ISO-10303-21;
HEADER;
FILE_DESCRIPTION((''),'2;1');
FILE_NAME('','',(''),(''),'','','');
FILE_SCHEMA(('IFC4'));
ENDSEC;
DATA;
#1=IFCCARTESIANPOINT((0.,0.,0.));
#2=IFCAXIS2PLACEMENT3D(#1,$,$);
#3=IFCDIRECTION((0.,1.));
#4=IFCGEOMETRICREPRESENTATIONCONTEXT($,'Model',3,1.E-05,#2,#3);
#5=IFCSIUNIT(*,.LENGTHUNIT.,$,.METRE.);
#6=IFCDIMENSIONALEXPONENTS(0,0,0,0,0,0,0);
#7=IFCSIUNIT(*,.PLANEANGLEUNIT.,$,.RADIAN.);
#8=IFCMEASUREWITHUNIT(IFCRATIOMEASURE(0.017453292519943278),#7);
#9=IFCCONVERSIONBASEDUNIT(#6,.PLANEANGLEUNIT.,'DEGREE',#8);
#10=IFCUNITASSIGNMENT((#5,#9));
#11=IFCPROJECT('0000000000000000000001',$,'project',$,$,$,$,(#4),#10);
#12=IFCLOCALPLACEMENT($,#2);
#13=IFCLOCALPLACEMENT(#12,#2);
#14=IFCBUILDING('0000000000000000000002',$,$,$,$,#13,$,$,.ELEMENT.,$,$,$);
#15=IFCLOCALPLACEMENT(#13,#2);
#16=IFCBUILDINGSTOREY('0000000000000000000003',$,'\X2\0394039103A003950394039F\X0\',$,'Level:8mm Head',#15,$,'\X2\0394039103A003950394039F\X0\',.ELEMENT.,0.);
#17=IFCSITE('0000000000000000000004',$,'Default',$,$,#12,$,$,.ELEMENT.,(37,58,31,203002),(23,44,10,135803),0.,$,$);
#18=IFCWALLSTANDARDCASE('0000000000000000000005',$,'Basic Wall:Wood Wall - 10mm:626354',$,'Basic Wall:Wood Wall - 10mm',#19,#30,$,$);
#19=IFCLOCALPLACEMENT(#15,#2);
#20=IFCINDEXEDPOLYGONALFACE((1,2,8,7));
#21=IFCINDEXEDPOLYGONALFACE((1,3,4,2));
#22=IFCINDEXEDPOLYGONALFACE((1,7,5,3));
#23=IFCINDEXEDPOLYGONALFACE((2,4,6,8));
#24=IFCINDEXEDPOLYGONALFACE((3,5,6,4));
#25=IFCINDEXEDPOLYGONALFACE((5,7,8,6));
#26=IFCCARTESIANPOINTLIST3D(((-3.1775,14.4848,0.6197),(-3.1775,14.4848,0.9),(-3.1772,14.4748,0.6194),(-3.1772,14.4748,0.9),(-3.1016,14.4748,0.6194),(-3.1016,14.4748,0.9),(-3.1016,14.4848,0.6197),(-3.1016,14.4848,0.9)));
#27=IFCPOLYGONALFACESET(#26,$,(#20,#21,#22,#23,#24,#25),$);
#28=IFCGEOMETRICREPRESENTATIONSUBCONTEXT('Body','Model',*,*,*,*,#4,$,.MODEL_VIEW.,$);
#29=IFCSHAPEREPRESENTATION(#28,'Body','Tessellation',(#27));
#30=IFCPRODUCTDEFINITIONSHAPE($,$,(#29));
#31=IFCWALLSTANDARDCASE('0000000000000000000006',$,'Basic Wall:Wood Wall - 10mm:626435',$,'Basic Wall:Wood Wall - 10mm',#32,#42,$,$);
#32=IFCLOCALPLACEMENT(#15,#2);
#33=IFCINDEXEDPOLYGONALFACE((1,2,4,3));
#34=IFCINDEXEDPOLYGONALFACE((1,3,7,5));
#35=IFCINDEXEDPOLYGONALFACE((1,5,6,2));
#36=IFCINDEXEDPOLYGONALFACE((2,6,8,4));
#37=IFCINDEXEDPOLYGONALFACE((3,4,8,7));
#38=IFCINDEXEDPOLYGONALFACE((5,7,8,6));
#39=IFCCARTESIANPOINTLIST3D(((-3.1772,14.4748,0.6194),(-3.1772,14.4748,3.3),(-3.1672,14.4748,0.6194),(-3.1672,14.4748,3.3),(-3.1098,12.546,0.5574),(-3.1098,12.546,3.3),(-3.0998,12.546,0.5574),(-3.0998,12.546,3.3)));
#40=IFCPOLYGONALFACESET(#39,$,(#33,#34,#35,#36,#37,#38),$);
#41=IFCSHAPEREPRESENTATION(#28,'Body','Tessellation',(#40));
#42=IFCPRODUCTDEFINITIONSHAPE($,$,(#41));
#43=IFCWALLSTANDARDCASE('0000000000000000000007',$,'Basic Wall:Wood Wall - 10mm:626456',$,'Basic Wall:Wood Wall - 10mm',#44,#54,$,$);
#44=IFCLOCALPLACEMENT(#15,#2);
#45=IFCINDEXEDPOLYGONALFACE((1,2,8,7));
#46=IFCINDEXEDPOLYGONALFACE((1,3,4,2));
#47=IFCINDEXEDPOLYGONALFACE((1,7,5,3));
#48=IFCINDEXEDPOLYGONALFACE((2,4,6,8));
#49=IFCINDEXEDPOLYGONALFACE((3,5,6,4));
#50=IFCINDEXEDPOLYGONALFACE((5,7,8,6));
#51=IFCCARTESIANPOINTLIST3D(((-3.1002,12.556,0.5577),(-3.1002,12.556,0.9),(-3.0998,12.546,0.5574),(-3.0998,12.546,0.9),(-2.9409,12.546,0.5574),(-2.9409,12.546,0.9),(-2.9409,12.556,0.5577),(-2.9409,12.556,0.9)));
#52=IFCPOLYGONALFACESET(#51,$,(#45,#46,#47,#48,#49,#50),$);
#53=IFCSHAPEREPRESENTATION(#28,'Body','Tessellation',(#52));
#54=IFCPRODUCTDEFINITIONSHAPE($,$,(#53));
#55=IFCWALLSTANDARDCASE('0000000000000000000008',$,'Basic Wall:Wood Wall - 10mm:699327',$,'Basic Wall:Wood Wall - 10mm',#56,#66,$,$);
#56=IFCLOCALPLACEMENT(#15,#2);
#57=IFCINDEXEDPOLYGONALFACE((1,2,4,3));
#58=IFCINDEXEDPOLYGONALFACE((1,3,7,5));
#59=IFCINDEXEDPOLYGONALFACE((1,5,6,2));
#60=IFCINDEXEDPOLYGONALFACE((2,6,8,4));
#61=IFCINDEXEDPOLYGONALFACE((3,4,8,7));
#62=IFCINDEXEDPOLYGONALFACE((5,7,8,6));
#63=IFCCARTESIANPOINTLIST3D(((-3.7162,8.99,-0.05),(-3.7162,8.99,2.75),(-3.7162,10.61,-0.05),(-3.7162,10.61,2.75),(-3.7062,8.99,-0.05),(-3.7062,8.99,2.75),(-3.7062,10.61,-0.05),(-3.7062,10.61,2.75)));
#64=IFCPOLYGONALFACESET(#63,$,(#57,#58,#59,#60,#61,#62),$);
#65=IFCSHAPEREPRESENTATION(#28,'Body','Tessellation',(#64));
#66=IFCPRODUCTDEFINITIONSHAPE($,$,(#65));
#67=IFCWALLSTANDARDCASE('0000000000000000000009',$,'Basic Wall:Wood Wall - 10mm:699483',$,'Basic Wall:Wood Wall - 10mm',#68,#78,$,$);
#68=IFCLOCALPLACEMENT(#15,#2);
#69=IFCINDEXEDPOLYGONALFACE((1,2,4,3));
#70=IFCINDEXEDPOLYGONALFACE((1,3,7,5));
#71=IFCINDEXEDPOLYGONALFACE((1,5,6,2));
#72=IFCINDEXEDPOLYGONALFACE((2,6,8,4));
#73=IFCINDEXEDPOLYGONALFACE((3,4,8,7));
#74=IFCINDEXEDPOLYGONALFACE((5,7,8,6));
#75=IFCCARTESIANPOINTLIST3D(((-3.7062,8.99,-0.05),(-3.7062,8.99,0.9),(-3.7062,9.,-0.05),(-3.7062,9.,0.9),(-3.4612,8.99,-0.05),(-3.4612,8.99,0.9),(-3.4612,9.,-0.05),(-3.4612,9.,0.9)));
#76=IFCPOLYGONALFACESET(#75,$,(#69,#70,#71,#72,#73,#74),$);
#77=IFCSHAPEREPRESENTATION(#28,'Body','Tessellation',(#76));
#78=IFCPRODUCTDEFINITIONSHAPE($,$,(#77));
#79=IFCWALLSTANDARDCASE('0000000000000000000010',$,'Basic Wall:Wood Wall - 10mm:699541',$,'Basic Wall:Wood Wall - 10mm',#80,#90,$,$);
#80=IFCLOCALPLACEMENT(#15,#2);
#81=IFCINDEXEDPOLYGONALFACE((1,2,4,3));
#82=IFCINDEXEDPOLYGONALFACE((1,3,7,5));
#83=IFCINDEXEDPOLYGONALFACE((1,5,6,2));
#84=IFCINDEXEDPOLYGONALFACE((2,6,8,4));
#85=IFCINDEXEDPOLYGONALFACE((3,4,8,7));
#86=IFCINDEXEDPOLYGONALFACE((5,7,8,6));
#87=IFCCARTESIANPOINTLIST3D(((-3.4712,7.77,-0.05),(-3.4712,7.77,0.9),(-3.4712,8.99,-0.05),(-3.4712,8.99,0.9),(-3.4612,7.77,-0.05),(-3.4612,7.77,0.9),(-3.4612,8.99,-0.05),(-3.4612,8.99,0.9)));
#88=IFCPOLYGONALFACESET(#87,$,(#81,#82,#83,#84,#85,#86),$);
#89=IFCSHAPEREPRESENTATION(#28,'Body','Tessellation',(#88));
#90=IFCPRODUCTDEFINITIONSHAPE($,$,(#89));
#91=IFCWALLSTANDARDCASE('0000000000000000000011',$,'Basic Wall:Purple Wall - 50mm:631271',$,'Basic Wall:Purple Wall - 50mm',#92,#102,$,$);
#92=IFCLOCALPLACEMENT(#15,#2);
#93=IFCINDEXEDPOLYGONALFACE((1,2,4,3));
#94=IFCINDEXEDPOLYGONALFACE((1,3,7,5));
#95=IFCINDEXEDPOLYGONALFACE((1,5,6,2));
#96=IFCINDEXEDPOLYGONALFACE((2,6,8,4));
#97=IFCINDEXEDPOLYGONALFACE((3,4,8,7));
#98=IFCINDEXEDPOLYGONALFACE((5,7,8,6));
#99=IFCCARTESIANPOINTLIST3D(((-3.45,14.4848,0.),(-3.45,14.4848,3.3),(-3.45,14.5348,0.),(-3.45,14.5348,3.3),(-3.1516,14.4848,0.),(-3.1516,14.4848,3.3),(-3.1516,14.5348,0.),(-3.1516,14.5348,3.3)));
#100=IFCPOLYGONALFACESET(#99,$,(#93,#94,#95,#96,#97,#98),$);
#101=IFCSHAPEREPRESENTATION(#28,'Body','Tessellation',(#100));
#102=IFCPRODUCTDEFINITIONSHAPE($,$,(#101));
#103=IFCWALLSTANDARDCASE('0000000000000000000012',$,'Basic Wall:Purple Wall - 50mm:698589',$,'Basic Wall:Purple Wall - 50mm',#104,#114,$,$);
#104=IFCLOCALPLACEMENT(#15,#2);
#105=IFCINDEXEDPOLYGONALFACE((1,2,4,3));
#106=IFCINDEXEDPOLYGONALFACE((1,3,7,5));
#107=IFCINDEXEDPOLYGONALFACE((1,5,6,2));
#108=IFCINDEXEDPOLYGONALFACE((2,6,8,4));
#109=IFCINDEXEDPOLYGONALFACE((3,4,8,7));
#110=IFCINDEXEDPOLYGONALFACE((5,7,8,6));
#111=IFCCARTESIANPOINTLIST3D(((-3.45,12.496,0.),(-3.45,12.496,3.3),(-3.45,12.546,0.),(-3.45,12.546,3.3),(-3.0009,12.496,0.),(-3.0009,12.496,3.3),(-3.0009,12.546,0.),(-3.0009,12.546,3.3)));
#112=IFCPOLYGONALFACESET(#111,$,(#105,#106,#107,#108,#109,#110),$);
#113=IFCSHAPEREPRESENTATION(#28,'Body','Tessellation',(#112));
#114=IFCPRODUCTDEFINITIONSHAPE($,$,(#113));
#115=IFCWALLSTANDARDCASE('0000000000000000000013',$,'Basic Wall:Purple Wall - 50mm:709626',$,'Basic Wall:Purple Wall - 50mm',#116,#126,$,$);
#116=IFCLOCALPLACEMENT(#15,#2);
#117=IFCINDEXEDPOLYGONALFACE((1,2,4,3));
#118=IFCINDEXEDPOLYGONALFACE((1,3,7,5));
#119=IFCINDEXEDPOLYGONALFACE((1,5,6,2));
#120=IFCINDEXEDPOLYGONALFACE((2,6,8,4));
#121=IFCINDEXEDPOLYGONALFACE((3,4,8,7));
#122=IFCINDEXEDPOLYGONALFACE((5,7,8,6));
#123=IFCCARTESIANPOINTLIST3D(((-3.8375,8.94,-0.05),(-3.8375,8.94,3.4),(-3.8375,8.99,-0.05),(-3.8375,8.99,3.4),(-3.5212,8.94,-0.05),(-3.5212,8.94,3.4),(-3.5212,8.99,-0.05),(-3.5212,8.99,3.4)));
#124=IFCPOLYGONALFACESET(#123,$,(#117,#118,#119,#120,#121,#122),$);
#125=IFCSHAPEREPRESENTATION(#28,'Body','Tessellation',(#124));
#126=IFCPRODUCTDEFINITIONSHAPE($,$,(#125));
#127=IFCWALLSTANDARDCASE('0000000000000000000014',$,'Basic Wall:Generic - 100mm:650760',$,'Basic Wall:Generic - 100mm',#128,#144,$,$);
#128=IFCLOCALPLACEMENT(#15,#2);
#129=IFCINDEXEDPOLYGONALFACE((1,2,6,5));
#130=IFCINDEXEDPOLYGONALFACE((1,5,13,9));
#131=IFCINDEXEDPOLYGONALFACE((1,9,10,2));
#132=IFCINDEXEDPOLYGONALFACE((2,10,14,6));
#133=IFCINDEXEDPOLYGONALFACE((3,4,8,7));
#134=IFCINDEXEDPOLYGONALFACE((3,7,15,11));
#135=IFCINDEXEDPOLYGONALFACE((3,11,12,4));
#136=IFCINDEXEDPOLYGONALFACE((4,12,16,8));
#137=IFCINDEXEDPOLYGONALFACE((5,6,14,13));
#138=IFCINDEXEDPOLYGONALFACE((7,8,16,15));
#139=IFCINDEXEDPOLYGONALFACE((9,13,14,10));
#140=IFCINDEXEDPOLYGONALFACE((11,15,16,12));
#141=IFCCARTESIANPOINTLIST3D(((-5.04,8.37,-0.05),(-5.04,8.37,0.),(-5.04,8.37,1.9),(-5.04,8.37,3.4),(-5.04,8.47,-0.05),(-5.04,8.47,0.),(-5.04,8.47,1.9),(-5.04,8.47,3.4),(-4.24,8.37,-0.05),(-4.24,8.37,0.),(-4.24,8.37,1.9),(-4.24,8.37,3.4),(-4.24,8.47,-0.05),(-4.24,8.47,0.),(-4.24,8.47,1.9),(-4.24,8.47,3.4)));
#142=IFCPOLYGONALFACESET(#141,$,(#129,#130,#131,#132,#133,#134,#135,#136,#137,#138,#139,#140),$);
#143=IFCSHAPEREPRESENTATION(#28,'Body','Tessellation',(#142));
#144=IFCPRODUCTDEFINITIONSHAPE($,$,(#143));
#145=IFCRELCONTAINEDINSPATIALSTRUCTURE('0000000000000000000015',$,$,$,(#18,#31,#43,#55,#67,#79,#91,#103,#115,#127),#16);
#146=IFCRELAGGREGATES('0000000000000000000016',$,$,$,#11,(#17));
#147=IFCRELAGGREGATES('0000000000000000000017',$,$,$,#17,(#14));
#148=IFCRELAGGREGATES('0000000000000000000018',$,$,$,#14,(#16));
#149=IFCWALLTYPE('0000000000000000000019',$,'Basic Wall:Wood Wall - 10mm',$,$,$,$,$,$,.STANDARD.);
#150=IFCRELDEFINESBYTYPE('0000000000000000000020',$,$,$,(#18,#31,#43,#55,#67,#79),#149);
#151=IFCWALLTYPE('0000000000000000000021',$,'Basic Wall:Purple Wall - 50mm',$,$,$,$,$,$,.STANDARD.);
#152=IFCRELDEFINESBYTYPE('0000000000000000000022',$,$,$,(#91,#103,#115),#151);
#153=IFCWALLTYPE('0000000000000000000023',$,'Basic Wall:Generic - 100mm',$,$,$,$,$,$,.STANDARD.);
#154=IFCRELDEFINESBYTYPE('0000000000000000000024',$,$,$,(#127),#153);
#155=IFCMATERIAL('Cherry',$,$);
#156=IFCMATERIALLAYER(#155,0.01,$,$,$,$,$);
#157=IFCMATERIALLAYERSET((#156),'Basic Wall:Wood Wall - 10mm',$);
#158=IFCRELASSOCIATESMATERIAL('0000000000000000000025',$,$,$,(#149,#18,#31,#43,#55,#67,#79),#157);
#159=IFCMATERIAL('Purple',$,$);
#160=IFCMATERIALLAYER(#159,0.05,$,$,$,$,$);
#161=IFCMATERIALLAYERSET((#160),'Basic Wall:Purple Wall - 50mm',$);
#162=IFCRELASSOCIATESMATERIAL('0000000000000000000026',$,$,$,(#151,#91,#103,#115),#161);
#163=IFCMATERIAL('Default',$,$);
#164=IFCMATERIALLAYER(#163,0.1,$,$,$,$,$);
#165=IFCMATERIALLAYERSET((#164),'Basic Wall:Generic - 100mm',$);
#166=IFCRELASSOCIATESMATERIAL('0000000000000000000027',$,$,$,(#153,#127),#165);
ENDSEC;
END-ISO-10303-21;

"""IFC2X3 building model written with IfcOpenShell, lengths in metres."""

from ifc_helpers import new_model, entity, si_unit, converted_unit, direction, frame, frame_2d, origin, place, context, subcontext, project, spatial, polyline, rectangle, outline, extrude, clip, bounded_halfspace, material, layer, layer_set, layer_usage, type_object, element, save


model = new_model("IFC2X3")

# Units and contexts
model_context = context("Model", 3, precision=1e-05, world=origin(), true_north=direction((0.0, 1.0)))
body_context = subcontext(model_context, "Body", "Model", "MODEL_VIEW")
ifc_project = project(units=[si_unit("LENGTHUNIT", "METRE"), converted_unit("PLANEANGLEUNIT", "DEGREE", entity("IfcRatioMeasure", 0.017453292519943278), si_unit("PLANEANGLEUNIT", "RADIAN"), dimensions=[0, 0, 0, 0, 0, 0, 0])], contexts=[model_context])

# Site, building, storey
site_placement = place(None, origin())
site = spatial("IfcSite", under=ifc_project, at=site_placement, Name="Default", CompositionType="ELEMENT", RefLatitude=(37, 58, 31, 203002), RefLongitude=(23, 44, 10, 135803), RefElevation=0.0)
building_placement = place(site_placement, origin())
building = spatial("IfcBuilding", under=site, at=building_placement, CompositionType="ELEMENT")
storey_placement = place(building_placement, origin())
storey = spatial("IfcBuildingStorey", under=building, at=storey_placement, Name="ΔΑΠΕΔΟ", ObjectType="Level:8mm Head", LongName="ΔΑΠΕΔΟ", CompositionType="ELEMENT", Elevation=0.0)

# Walls
ifc_material_1 = material(Name="Cherry")
ifc_layer_1 = layer(ifc_material_1, 0.01)
ifc_layer_set_1 = layer_set([ifc_layer_1], Name="Basic Wall:Wood Wall - 10mm")
ifc_layer_usage_1 = layer_usage(ifc_layer_set_1, "AXIS2", "POSITIVE", -0.005)
wall_type_1 = type_object("IfcWallType", Name="Basic Wall:Wood Wall - 10mm", PredefinedType="STANDARD", material=ifc_layer_set_1)
wall_1_placement = place(storey_placement, frame((-3.1016, 14.4798, 0.6194), z_axis=(0.0, 0.0, 1.0), x_axis=(-1.0, 0.0, 0.0)))
element("IfcWallStandardCase", 1, at=wall_1_placement, inside=storey, type_object=wall_type_1, material=ifc_layer_usage_1, Name="Basic Wall:Wood Wall - 10mm:626354", ObjectType="Basic Wall:Wood Wall - 10mm", context=body_context, shape_type="Clipping", body=[
    clip(extrude(outline(polyline([(0.0, -0.005), (0.076, -0.005), (0.0756, 0.005), (0.0, 0.005), (0.0, -0.005)])), origin(), (0.0, 0.0, 1.0), 0.2806), bounded_halfspace(frame((0.076, -0.005, 0.0003), z_axis=(0.0, 0.032108, 0.999484), x_axis=(-1.0, 0.0, 0.0)), True, frame((0.076, -0.005, 0.0003)), polyline([(0.0, 0.0), (-0.0003, 0.01), (-0.0104, 0.01), (-0.076, 0.01), (-0.076, 0.0), (0.0, 0.0)]))),
])
wall_2_placement = place(storey_placement, frame((-3.1722, 14.475, 0.5574), z_axis=(0.0, 0.0, 1.0), x_axis=(0.034899, -0.999391, 0.0)))
element("IfcWallStandardCase", 2, at=wall_2_placement, inside=storey, type_object=wall_type_1, material=ifc_layer_usage_1, Name="Basic Wall:Wood Wall - 10mm:626435", ObjectType="Basic Wall:Wood Wall - 10mm", context=body_context, shape_type="Clipping", body=[
    clip(extrude(outline(polyline([(0.0, -0.005), (1.93, -0.005), (1.9303, 0.005), (0.0003, 0.005), (0.0, -0.005)])), origin(), (0.0, 0.0, 1.0), 2.7426), bounded_halfspace(frame((1.93, -0.005, 0.0), z_axis=(0.032088, -0.001121, 0.999484), x_axis=(0.034899, 0.999391, 0.0)), True, frame((1.93, -0.005, 0.0)), polyline([(0.0, 0.0), (0.0003, 0.01), (-0.0097, 0.01), (-1.9296, 0.01), (-1.93, 0.0), (0.0, 0.0)]))),
])
wall_3_placement = place(storey_placement, frame((-3.1002, 12.551, 0.5574)))
element("IfcWallStandardCase", 3, at=wall_3_placement, inside=storey, type_object=wall_type_1, material=ifc_layer_usage_1, Name="Basic Wall:Wood Wall - 10mm:626456", ObjectType="Basic Wall:Wood Wall - 10mm", context=body_context, shape_type="Clipping", body=[
    clip(extrude(outline(polyline([(0.0003, -0.005), (0.1492, -0.005), (0.1592, -0.005), (0.1592, 0.005), (0.0, 0.005), (0.0003, -0.005)])), origin(), (0.0, 0.0, 1.0), 0.3426), bounded_halfspace(frame((0.1592, -0.005, 0.0), z_axis=(0.0, -0.032108, 0.999484), x_axis=(1.0, 0.0, 0.0)), True, frame((0.1592, -0.005, 0.0)), polyline([(0.0, 0.0), (0.0, 0.01), (-0.1592, 0.01), (-0.1589, 0.0), (-0.01, 0.0), (0.0, 0.0)]))),
])
ifc_layer_usage_2 = layer_usage(ifc_layer_set_1, "AXIS2", "NEGATIVE", 0.005)
wall_4_placement = place(storey_placement, frame((-3.7112, 10.61, -0.05), z_axis=(0.0, 0.0, 1.0), x_axis=(0.0, -1.0, 0.0)))
element("IfcWallStandardCase", 4, at=wall_4_placement, inside=storey, type_object=wall_type_1, material=ifc_layer_usage_2, Name="Basic Wall:Wood Wall - 10mm:699327", ObjectType="Basic Wall:Wood Wall - 10mm", context=body_context, shape_type="Clipping", body=[
    clip(clip(extrude(rectangle(XDim=1.62, YDim=0.01, at=frame_2d((0.81, 0.0), x_axis=(-1.0, 0.0))), origin(), (0.0, 0.0, 1.0), 2.8), bounded_halfspace(frame((0.0, -0.005, 2.8), z_axis=(0.0, 0.0, -1.0), x_axis=(0.0, 1.0, 0.0)), True, frame((0.0, -0.005, 2.8)), polyline([(0.0, 0.0), (1.62, 0.0), (1.62, 0.01), (0.0, 0.01), (0.0, 0.0)]))), bounded_halfspace(frame((1.62, -0.005, 0.0), z_axis=(0.0, 0.0, 1.0), x_axis=(-1.0, 0.0, 0.0)), True, frame((1.62, -0.005, 0.0), z_axis=(0.0, 0.0, 1.0), x_axis=(-1.0, 0.0, 0.0)), polyline([(0.0, 0.0), (0.0, -0.01), (0.01, -0.01), (1.62, -0.01), (1.62, 0.0), (0.0, 0.0)]))),
])
wall_5_placement = place(storey_placement, frame((-3.7062, 8.995, -0.05)))
element("IfcWallStandardCase", 5, at=wall_5_placement, inside=storey, type_object=wall_type_1, material=ifc_layer_usage_2, Name="Basic Wall:Wood Wall - 10mm:699483", ObjectType="Basic Wall:Wood Wall - 10mm", context=body_context, shape_type="Clipping", body=[
    clip(extrude(rectangle(XDim=0.245, YDim=0.01, at=frame_2d((0.1225, 0.0), x_axis=(-1.0, 0.0))), origin(), (0.0, 0.0, 1.0), 0.95), bounded_halfspace(frame((0.245, -0.005, 0.0), z_axis=(0.0, 0.0, 1.0), x_axis=(0.0, 1.0, 0.0)), True, frame((0.245, -0.005, 0.0), z_axis=(0.0, 0.0, 1.0), x_axis=(0.0, 1.0, 0.0)), polyline([(0.0, 0.0), (0.01, 0.0), (0.01, 0.245), (0.0, 0.245), (0.0, 0.06), (0.0, 0.01), (0.0, 0.0)]))),
])
wall_6_placement = place(storey_placement, frame((-3.4662, 8.99, -0.05), z_axis=(0.0, 0.0, 1.0), x_axis=(0.0, -1.0, 0.0)))
element("IfcWallStandardCase", 6, at=wall_6_placement, inside=storey, type_object=wall_type_1, material=ifc_layer_usage_2, Name="Basic Wall:Wood Wall - 10mm:699541", ObjectType="Basic Wall:Wood Wall - 10mm", context=body_context, shape_type="Clipping", body=[
    clip(extrude(rectangle(XDim=1.22, YDim=0.01, at=frame_2d((0.61, 0.0), x_axis=(-1.0, 0.0))), origin(), (0.0, 0.0, 1.0), 0.95), bounded_halfspace(frame((1.22, -0.005, 0.0), z_axis=(0.0, 0.0, 1.0), x_axis=(-1.0, 0.0, 0.0)), True, frame((1.22, -0.005, 0.0), z_axis=(0.0, 0.0, 1.0), x_axis=(-1.0, 0.0, 0.0)), polyline([(0.0, 0.0), (0.0, -0.01), (0.01, -0.01), (1.22, -0.01), (1.22, 0.0), (0.06, 0.0), (0.01, 0.0), (0.0, 0.0)]))),
])
ifc_material_2 = material(Name="Purple")
ifc_layer_2 = layer(ifc_material_2, 0.05)
ifc_layer_set_2 = layer_set([ifc_layer_2], Name="Basic Wall:Purple Wall - 50mm")
ifc_layer_usage_3 = layer_usage(ifc_layer_set_2, "AXIS2", "NEGATIVE", 0.025)
wall_type_2 = type_object("IfcWallType", Name="Basic Wall:Purple Wall - 50mm", PredefinedType="STANDARD", material=ifc_layer_set_2)
wall_7_placement = place(storey_placement, frame((-3.1516, 14.5098, 0.0), z_axis=(0.0, 0.0, 1.0), x_axis=(-1.0, 0.0, 0.0)))
element("IfcWallStandardCase", 7, at=wall_7_placement, inside=storey, type_object=wall_type_2, material=ifc_layer_usage_3, Name="Basic Wall:Purple Wall - 50mm:631271", ObjectType="Basic Wall:Purple Wall - 50mm", context=body_context, shape_type="Clipping", body=[
    clip(extrude(rectangle(XDim=0.2984, YDim=0.05, at=frame_2d((0.1492, 0.0), x_axis=(-1.0, 0.0))), origin(), (0.0, 0.0, 1.0), 3.3), bounded_halfspace(frame((0.0, -0.025, 0.0), z_axis=(1.0, 0.0, 0.0), x_axis=(0.0, 1.0, 0.0)), True, frame((0.0, -0.025, 0.0), z_axis=(1.0, 0.0, 0.0), x_axis=(0.0, 1.0, 0.0)), polyline([(0.0, 0.0), (0.05, 0.0), (0.05, 3.3), (0.0, 3.3), (0.0, 0.6213), (0.0, 0.5713), (0.0, 0.0)]))),
])
wall_8_placement = place(storey_placement, frame((-3.45, 12.521, 0.0)))
element("IfcWallStandardCase", 8, at=wall_8_placement, inside=storey, type_object=wall_type_2, material=ifc_layer_usage_3, Name="Basic Wall:Purple Wall - 50mm:698589", ObjectType="Basic Wall:Purple Wall - 50mm", context=body_context, shape_type="SweptSolid", body=[
    extrude(rectangle(XDim=0.4491, YDim=0.05, at=frame_2d((0.2245, 0.0), x_axis=(-1.0, 0.0))), origin(), (0.0, 0.0, 1.0), 3.3),
])
ifc_layer_usage_4 = layer_usage(ifc_layer_set_2, "AXIS2", "POSITIVE", -0.025)
wall_9_placement = place(storey_placement, frame((-3.5212, 8.965, -0.05), z_axis=(0.0, 0.0, 1.0), x_axis=(-1.0, 0.0, 0.0)))
element("IfcWallStandardCase", 9, at=wall_9_placement, inside=storey, type_object=wall_type_2, material=ifc_layer_usage_4, Name="Basic Wall:Purple Wall - 50mm:709626", ObjectType="Basic Wall:Purple Wall - 50mm", context=body_context, shape_type="Clipping", body=[
    clip(clip(extrude(rectangle(XDim=0.3162, YDim=0.05, at=frame_2d((0.1581, 0.0), x_axis=(-1.0, 0.0))), origin(), (0.0, 0.0, 1.0), 3.45), bounded_halfspace(frame((0.0, -0.025, 3.45), z_axis=(0.0, 0.0, -1.0), x_axis=(0.0, 1.0, 0.0)), True, frame((0.0, -0.025, 3.45), z_axis=(0.0, 0.0, -1.0), x_axis=(0.0, 1.0, 0.0)), polyline([(0.0, 0.0), (0.05, 0.0), (0.05, 0.3162), (0.0, 0.3162), (0.0, 0.0)]))), bounded_halfspace(frame((0.3162, -0.025, 0.0), z_axis=(0.0, 0.0, 1.0), x_axis=(0.0, -1.0, 0.0)), True, frame((0.3162, -0.025, 0.0), z_axis=(0.0, 0.0, 1.0), x_axis=(0.0, -1.0, 0.0)), polyline([(0.0, 0.0), (-0.05, 0.0), (-0.05, -0.3162), (0.0, -0.3162), (0.0, -0.1312), (0.0, -0.1212), (0.0, 0.0)]))),
])

# Wall, opening
ifc_material_3 = material(Name="Default")
ifc_layer_3 = layer(ifc_material_3, 0.1)
ifc_layer_set_3 = layer_set([ifc_layer_3], Name="Basic Wall:Generic - 100mm")
ifc_layer_usage_5 = layer_usage(ifc_layer_set_3, "AXIS2", "NEGATIVE", 0.05)
wall_type_3 = type_object("IfcWallType", Name="Basic Wall:Generic - 100mm", PredefinedType="STANDARD", material=ifc_layer_set_3)
wall_10_placement = place(storey_placement, frame((-4.24, 8.42, -0.05), z_axis=(0.0, 0.0, 1.0), x_axis=(-1.0, 0.0, 0.0)))
wall_10 = element("IfcWallStandardCase", 10, at=wall_10_placement, inside=storey, type_object=wall_type_3, material=ifc_layer_usage_5, Name="Basic Wall:Generic - 100mm:650760", ObjectType="Basic Wall:Generic - 100mm", context=body_context, shape_type="Clipping", body=[
    clip(clip(extrude(rectangle(XDim=0.8, YDim=0.1, at=frame_2d((0.4, 0.0), x_axis=(-1.0, 0.0))), origin(), (0.0, 0.0, 1.0), 3.45), bounded_halfspace(frame((0.0, -0.05, 3.45), z_axis=(0.0, 0.0, -1.0), x_axis=(0.0, 1.0, 0.0)), True, frame((0.0, -0.05, 3.45), z_axis=(0.0, 0.0, -1.0), x_axis=(0.0, 1.0, 0.0)), polyline([(0.0, 0.0), (0.1, 0.0), (0.1, 0.8), (0.0, 0.8), (0.0, 0.0)]))), bounded_halfspace(frame((0.8, -0.05, 0.0), z_axis=(0.0, 0.0, 1.0), x_axis=(0.0, -1.0, 0.0)), True, frame((0.8, -0.05, 0.0), z_axis=(0.0, 0.0, 1.0), x_axis=(0.0, -1.0, 0.0)), polyline([(0.0, 0.0), (-0.1, 0.0), (-0.1, -0.8), (0.0, -0.8), (0.0, 0.0)]))),
])
opening_1_placement = place(wall_10_placement, origin())
element("IfcOpeningElement", 11, at=opening_1_placement, cuts=wall_10, ObjectType="Opening", context=body_context, shape_type="SweptSolid", body=[
    extrude(rectangle(XDim=1.9, YDim=0.8, at=frame_2d((0.0, 0.0), x_axis=(0.0, 1.0))), frame((0.4, -1.474, 1.0), z_axis=(0.0, 1.0, 0.0), x_axis=(1.0, 0.0, 0.0)), (0.0, 0.0, 1.0), 3.048),
])

save(model, "model.ifc")
